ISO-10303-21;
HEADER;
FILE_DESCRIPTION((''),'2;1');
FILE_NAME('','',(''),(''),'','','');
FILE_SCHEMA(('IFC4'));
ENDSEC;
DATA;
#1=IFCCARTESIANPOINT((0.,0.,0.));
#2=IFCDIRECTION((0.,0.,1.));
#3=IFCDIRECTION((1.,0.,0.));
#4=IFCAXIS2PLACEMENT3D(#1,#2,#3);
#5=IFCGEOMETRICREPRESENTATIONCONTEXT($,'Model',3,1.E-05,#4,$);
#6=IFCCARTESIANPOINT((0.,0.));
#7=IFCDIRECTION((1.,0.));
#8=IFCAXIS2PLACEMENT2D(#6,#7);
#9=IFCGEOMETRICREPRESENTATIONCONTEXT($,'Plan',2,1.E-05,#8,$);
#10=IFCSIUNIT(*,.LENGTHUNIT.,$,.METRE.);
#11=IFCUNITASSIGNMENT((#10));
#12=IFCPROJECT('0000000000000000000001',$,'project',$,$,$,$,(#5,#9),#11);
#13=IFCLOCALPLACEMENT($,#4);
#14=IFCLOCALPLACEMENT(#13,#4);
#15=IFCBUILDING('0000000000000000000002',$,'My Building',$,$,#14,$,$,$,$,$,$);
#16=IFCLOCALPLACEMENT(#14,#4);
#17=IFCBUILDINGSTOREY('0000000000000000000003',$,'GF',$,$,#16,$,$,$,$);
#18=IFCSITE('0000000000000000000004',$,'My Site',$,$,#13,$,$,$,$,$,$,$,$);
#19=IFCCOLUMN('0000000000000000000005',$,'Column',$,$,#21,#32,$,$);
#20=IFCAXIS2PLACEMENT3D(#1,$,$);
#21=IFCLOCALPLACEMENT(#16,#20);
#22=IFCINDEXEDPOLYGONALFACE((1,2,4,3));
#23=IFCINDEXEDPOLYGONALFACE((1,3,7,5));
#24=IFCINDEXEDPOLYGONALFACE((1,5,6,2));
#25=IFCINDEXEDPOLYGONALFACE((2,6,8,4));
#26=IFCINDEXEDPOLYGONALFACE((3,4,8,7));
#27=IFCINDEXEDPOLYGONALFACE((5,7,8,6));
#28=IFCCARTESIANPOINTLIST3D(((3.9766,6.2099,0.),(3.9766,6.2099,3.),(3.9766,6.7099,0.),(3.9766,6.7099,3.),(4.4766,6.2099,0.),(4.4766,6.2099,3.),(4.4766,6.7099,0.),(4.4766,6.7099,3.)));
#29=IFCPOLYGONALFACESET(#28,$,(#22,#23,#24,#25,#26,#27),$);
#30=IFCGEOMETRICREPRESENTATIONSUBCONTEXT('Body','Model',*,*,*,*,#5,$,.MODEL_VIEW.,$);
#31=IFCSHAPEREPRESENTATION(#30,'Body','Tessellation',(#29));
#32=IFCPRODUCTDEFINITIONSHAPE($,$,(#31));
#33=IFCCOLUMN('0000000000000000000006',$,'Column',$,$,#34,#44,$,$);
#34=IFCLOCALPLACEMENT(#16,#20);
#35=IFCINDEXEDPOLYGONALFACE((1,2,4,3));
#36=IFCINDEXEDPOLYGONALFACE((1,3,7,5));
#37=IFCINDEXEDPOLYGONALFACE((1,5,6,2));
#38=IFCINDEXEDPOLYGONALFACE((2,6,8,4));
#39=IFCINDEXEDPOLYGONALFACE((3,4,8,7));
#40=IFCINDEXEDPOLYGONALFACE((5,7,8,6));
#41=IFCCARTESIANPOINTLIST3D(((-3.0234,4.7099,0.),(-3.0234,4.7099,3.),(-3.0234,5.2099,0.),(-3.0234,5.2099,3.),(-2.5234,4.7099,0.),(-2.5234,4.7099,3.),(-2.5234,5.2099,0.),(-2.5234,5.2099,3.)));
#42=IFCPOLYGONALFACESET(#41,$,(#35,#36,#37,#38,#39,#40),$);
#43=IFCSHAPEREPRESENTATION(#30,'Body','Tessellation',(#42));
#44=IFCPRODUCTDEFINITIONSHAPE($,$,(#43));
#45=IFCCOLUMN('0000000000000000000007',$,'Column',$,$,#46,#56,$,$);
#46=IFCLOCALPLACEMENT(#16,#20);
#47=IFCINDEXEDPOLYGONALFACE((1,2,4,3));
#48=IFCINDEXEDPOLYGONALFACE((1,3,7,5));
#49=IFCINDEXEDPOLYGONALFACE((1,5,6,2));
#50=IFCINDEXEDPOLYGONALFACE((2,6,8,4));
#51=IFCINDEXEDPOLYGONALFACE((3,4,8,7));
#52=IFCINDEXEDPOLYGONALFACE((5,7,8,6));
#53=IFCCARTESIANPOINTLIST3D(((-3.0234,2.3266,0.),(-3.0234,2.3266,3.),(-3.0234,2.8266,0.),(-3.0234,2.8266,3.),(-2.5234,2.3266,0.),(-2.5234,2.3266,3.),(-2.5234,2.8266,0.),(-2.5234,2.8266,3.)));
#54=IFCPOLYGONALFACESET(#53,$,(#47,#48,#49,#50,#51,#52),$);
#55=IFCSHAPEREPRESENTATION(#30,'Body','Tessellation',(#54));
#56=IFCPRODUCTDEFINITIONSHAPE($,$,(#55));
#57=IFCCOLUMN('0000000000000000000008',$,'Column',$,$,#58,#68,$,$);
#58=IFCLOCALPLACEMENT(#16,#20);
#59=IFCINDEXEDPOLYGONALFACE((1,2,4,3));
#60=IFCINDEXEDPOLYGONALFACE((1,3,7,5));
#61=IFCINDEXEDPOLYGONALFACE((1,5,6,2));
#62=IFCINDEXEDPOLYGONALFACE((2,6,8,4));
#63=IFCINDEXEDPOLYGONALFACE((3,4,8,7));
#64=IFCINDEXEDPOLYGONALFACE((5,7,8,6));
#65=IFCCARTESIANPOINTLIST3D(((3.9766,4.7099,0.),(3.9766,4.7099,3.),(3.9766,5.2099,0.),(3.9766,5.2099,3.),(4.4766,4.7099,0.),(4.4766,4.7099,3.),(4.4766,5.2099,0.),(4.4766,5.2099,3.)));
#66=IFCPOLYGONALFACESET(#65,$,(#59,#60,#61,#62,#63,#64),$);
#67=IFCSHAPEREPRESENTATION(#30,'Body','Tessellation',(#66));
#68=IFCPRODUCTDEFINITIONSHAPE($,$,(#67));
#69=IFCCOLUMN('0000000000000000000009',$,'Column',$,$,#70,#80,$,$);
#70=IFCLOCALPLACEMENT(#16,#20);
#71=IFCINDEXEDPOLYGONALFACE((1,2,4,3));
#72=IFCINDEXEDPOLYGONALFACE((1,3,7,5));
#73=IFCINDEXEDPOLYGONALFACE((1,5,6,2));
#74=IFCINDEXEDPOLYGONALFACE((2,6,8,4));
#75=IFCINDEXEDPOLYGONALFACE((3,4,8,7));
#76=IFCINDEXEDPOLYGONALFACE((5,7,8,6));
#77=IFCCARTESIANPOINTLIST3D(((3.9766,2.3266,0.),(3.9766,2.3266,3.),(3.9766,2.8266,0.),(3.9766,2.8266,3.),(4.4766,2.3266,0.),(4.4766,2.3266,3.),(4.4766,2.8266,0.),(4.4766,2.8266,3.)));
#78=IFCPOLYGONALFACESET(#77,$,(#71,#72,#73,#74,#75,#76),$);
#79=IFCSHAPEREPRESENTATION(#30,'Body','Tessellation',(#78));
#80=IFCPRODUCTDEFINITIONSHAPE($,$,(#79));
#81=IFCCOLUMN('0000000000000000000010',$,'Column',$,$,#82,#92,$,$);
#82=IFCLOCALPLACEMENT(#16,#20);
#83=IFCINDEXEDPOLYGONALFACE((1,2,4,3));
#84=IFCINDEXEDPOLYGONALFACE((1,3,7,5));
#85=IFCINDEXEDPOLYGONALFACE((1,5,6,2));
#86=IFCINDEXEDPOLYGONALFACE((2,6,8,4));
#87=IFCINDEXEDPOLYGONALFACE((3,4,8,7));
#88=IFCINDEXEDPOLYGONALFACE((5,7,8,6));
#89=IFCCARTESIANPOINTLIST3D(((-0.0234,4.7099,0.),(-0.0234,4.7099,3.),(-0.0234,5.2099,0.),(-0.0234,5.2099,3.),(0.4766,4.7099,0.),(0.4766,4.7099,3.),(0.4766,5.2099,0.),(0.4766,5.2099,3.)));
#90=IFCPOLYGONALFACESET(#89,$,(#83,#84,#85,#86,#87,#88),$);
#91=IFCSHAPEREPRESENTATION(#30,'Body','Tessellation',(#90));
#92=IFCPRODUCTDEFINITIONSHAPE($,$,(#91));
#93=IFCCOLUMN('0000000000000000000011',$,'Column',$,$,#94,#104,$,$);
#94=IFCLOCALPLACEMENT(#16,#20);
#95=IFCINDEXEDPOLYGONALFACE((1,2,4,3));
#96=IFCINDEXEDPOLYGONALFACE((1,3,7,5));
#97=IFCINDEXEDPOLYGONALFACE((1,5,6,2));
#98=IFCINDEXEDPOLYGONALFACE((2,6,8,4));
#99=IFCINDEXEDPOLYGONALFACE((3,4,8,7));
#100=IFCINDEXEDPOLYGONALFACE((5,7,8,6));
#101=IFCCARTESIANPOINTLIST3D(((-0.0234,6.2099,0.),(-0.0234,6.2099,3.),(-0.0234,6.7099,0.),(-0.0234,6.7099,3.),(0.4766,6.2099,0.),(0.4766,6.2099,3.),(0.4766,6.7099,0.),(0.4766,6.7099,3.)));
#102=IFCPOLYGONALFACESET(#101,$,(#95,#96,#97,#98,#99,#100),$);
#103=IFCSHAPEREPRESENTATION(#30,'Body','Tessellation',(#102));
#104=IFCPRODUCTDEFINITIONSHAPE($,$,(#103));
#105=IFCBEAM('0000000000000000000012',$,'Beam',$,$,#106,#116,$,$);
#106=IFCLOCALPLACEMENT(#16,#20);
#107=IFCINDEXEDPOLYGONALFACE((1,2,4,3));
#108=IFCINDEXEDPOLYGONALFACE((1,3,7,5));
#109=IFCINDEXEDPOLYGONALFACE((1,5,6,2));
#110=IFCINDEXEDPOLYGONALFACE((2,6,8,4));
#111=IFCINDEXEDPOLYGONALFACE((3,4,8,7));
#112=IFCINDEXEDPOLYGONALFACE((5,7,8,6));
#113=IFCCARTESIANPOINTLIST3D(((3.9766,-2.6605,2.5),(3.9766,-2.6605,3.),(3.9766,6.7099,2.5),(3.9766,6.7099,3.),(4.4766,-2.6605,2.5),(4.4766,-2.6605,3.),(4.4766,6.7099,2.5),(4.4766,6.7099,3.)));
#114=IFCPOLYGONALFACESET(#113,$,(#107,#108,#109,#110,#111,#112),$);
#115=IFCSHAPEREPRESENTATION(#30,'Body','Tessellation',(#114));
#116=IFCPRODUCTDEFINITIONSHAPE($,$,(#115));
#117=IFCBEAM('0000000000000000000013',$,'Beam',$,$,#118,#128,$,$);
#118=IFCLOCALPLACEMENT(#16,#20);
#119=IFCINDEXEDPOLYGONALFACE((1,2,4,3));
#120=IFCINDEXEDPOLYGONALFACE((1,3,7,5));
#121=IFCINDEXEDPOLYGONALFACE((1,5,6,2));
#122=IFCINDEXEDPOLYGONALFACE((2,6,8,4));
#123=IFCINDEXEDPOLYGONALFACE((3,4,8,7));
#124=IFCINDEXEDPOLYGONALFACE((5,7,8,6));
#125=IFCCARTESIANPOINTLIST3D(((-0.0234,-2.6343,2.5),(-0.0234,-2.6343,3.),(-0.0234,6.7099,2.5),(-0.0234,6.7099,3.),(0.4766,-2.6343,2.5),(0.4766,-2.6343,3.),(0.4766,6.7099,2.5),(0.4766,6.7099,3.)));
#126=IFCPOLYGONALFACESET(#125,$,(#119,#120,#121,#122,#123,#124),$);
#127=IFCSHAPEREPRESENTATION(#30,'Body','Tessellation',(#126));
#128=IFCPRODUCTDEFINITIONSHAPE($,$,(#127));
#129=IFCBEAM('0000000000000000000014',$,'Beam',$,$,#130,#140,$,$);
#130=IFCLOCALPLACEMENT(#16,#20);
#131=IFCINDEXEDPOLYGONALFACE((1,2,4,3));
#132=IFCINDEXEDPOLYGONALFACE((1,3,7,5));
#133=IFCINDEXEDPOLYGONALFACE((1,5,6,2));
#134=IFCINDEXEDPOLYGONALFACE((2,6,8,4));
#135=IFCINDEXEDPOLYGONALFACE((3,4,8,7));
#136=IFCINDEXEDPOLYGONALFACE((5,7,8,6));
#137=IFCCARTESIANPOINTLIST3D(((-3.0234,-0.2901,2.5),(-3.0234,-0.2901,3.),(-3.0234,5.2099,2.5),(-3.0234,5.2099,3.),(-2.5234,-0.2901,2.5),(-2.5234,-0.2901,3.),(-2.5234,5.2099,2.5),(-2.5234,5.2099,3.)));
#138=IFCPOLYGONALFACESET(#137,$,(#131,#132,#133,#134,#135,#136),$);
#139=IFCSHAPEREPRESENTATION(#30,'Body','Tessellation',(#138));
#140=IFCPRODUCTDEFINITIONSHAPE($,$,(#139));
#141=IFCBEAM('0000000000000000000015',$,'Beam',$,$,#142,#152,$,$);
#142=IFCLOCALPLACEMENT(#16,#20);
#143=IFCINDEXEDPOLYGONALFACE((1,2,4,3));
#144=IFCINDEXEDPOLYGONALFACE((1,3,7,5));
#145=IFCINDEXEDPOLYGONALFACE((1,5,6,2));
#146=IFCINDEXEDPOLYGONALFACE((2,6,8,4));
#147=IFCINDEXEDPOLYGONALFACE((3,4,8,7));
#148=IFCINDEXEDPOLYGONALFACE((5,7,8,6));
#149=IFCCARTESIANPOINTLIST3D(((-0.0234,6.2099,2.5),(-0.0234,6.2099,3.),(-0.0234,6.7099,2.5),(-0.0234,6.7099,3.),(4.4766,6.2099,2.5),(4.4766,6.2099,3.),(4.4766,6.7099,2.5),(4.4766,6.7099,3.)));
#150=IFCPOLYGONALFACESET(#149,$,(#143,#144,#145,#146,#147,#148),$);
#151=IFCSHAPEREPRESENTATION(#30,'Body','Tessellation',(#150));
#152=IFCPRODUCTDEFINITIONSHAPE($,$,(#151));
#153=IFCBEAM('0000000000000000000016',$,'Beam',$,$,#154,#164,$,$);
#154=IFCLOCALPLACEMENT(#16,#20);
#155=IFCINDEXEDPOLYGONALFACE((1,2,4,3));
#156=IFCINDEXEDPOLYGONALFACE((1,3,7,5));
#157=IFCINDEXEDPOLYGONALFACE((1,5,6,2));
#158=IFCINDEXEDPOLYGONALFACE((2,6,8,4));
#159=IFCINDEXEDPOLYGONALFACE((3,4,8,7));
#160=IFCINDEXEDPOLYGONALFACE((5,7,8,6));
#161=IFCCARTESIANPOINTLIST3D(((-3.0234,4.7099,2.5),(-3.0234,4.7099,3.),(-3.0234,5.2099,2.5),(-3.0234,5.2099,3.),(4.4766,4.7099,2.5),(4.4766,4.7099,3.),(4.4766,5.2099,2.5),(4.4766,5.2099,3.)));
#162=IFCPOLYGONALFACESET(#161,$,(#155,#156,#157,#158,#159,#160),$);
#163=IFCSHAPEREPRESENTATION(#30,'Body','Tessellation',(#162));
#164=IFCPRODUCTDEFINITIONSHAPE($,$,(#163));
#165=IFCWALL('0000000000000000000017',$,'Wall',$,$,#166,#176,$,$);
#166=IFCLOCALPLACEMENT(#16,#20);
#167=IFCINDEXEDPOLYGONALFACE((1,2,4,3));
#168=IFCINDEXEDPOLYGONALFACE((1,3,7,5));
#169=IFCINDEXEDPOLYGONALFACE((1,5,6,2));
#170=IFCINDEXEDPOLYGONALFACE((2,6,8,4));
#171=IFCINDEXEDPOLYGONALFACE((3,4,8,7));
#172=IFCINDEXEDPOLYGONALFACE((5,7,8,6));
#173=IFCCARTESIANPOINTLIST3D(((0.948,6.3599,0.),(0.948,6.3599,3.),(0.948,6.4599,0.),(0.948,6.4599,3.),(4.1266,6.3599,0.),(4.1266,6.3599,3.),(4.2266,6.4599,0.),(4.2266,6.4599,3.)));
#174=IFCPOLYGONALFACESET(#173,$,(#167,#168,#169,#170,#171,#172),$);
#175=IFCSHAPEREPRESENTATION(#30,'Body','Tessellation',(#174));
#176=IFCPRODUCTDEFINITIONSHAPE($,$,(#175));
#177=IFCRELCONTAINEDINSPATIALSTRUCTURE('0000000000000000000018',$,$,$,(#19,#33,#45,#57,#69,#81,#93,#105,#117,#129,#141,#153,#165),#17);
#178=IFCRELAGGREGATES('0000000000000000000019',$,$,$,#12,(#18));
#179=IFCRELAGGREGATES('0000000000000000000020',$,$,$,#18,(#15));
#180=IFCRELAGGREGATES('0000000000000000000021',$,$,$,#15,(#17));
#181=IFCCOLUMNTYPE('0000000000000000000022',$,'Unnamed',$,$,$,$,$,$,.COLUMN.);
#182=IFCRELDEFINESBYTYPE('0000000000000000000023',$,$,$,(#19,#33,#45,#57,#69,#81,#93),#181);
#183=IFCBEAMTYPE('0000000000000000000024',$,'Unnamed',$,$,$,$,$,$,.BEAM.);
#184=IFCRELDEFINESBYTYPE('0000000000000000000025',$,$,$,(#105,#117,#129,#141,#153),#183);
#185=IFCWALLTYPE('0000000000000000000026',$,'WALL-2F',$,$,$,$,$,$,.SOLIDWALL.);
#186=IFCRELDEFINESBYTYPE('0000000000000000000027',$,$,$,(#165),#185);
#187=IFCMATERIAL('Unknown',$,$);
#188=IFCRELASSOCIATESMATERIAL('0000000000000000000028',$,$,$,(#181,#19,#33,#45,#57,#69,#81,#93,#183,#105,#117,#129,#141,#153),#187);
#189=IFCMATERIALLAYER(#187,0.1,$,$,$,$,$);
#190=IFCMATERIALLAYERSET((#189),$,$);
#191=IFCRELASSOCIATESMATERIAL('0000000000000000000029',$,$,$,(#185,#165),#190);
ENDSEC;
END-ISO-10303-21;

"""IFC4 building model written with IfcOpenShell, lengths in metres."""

from ifc_helpers import new_model, si_unit, frame, origin_with_axes, origin_2d_with_axis, place, context, subcontext, project, spatial, line, indexed_curve, rectangle, outline, extrude, material, layer, layer_set, layer_usage, material_profile, profile_set, profile_usage, type_object, element, save


model = new_model("IFC4")

# Units and contexts
model_context = context("Model", 3, precision=1e-05, world=origin_with_axes())
plan_context = context("Plan", 2, precision=1e-05, world=origin_2d_with_axis())
body_context_1 = subcontext(model_context, "Body", "Model", "MODEL_VIEW")
ifc_project = project(units=[si_unit("LENGTHUNIT", "METRE")], contexts=[model_context, plan_context])

# Site, building, storey
site_placement = place(None, origin_with_axes())
site = spatial("IfcSite", under=ifc_project, at=site_placement, Name="My Site")
building_placement = place(site_placement, origin_with_axes())
building = spatial("IfcBuilding", under=site, at=building_placement, Name="My Building")
storey_placement = place(building_placement, origin_with_axes())
storey = spatial("IfcBuildingStorey", under=building, at=storey_placement, Name="GF")

# Columns
ifc_material_1 = material(Name="Unknown")
ifc_material_profile_1 = material_profile(ifc_material_1, rectangle(XDim=0.5, YDim=0.5))
ifc_profile_set_1 = profile_set([ifc_material_profile_1])
ifc_profile_usage_1 = profile_usage(ifc_profile_set_1, cardinal=5)
column_type = type_object("IfcColumnType", Name="Unnamed", PredefinedType="COLUMN", material=ifc_profile_set_1)
column_1_placement = place(storey_placement, frame((4.2266, 6.4599, 0.0), z_axis=(0.0, 0.0, 1.0), x_axis=(1.0, 0.0, 0.0)))
element("IfcColumn", 1, at=column_1_placement, inside=storey, type_object=column_type, material=ifc_profile_usage_1, Name="Column", context=body_context_1, shape_type="SweptSolid", body=[
    extrude(rectangle(XDim=0.5, YDim=0.5), origin_with_axes(), (0.0, 0.0, 1.0), 3.0),
])
ifc_profile_usage_2 = profile_usage(ifc_profile_set_1, cardinal=5)
column_2_placement = place(storey_placement, frame((-2.7734, 4.9599, 0.0), z_axis=(0.0, 0.0, 1.0), x_axis=(1.0, 0.0, 0.0)))
element("IfcColumn", 2, at=column_2_placement, inside=storey, type_object=column_type, material=ifc_profile_usage_2, Name="Column", context=body_context_1, shape_type="SweptSolid", body=[
    extrude(rectangle(XDim=0.5, YDim=0.5), origin_with_axes(), (0.0, 0.0, 1.0), 3.0),
])
ifc_profile_usage_3 = profile_usage(ifc_profile_set_1, cardinal=5)
column_3_placement = place(storey_placement, frame((-2.7734, 2.5766, 0.0), z_axis=(0.0, 0.0, 1.0), x_axis=(1.0, 0.0, 0.0)))
element("IfcColumn", 3, at=column_3_placement, inside=storey, type_object=column_type, material=ifc_profile_usage_3, Name="Column", context=body_context_1, shape_type="SweptSolid", body=[
    extrude(rectangle(XDim=0.5, YDim=0.5), origin_with_axes(), (0.0, 0.0, 1.0), 3.0),
])
ifc_profile_usage_4 = profile_usage(ifc_profile_set_1, cardinal=5)
column_4_placement = place(storey_placement, frame((4.2266, 4.9599, 0.0), z_axis=(0.0, 0.0, 1.0), x_axis=(1.0, 0.0, 0.0)))
element("IfcColumn", 4, at=column_4_placement, inside=storey, type_object=column_type, material=ifc_profile_usage_4, Name="Column", context=body_context_1, shape_type="SweptSolid", body=[
    extrude(rectangle(XDim=0.5, YDim=0.5), origin_with_axes(), (0.0, 0.0, 1.0), 3.0),
])
ifc_profile_usage_5 = profile_usage(ifc_profile_set_1, cardinal=5)
column_5_placement = place(storey_placement, frame((4.2266, 2.5766, 0.0), z_axis=(0.0, 0.0, 1.0), x_axis=(1.0, 0.0, 0.0)))
element("IfcColumn", 5, at=column_5_placement, inside=storey, type_object=column_type, material=ifc_profile_usage_5, Name="Column", context=body_context_1, shape_type="SweptSolid", body=[
    extrude(rectangle(XDim=0.5, YDim=0.5), origin_with_axes(), (0.0, 0.0, 1.0), 3.0),
])
ifc_profile_usage_6 = profile_usage(ifc_profile_set_1, cardinal=5)
column_6_placement = place(storey_placement, frame((0.2266, 4.9599, 0.0), z_axis=(0.0, 0.0, 1.0), x_axis=(1.0, 0.0, 0.0)))
element("IfcColumn", 6, at=column_6_placement, inside=storey, type_object=column_type, material=ifc_profile_usage_6, Name="Column", context=body_context_1, shape_type="SweptSolid", body=[
    extrude(rectangle(XDim=0.5, YDim=0.5), origin_with_axes(), (0.0, 0.0, 1.0), 3.0),
])
ifc_profile_usage_7 = profile_usage(ifc_profile_set_1, cardinal=5)
column_7_placement = place(storey_placement, frame((0.2266, 6.4599, 0.0), z_axis=(0.0, 0.0, 1.0), x_axis=(1.0, 0.0, 0.0)))
element("IfcColumn", 7, at=column_7_placement, inside=storey, type_object=column_type, material=ifc_profile_usage_7, Name="Column", context=body_context_1, shape_type="SweptSolid", body=[
    extrude(rectangle(XDim=0.5, YDim=0.5), origin_with_axes(), (0.0, 0.0, 1.0), 3.0),
])

# Beams
ifc_material_profile_2 = material_profile(ifc_material_1, rectangle(XDim=0.5, YDim=0.5))
ifc_profile_set_2 = profile_set([ifc_material_profile_2])
ifc_profile_usage_8 = profile_usage(ifc_profile_set_2, cardinal=7)
beam_type = type_object("IfcBeamType", Name="Unnamed", PredefinedType="BEAM", material=ifc_profile_set_2)
beam_1_placement = place(storey_placement, frame((4.4766, 6.7099, 3.0), z_axis=(0.0, -1.0, 0.0), x_axis=(1.0, 0.0, 0.0)))
element("IfcBeam", 8, at=beam_1_placement, inside=storey, type_object=beam_type, material=ifc_profile_usage_8, Name="Beam", context=body_context_1, shape_type="SweptSolid", body=[
    extrude(rectangle(XDim=0.5, YDim=0.5), frame((-0.25, -0.25, 0.0), z_axis=(0.0, 0.0, 1.0), x_axis=(1.0, 0.0, 0.0)), (0.0, 0.0, 1.0), 9.3704),
])
ifc_profile_usage_9 = profile_usage(ifc_profile_set_2, cardinal=7)
beam_2_placement = place(storey_placement, frame((0.4766, 6.7099, 3.0), z_axis=(0.0, -1.0, 0.0), x_axis=(1.0, 0.0, 0.0)))
element("IfcBeam", 9, at=beam_2_placement, inside=storey, type_object=beam_type, material=ifc_profile_usage_9, Name="Beam", context=body_context_1, shape_type="SweptSolid", body=[
    extrude(rectangle(XDim=0.5, YDim=0.5), frame((-0.25, -0.25, 0.0), z_axis=(0.0, 0.0, 1.0), x_axis=(1.0, 0.0, 0.0)), (0.0, 0.0, 1.0), 9.3442),
])
ifc_profile_usage_10 = profile_usage(ifc_profile_set_2, cardinal=7)
beam_3_placement = place(storey_placement, frame((-2.5234, 5.2099, 3.0), z_axis=(0.0, -1.0, 0.0), x_axis=(1.0, 0.0, 0.0)))
element("IfcBeam", 10, at=beam_3_placement, inside=storey, type_object=beam_type, material=ifc_profile_usage_10, Name="Beam", context=body_context_1, shape_type="SweptSolid", body=[
    extrude(rectangle(XDim=0.5, YDim=0.5), frame((-0.25, -0.25, 0.0), z_axis=(0.0, 0.0, 1.0), x_axis=(1.0, 0.0, 0.0)), (0.0, 0.0, 1.0), 5.5),
])
ifc_profile_usage_11 = profile_usage(ifc_profile_set_2, cardinal=7)
beam_4_placement = place(storey_placement, frame((-0.0234, 6.7099, 3.0), z_axis=(1.0, 0.0, 0.0), x_axis=(0.0, 1.0, 0.0)))
element("IfcBeam", 11, at=beam_4_placement, inside=storey, type_object=beam_type, material=ifc_profile_usage_11, Name="Beam", context=body_context_1, shape_type="SweptSolid", body=[
    extrude(rectangle(XDim=0.5, YDim=0.5), frame((-0.25, -0.25, 0.0), z_axis=(0.0, 0.0, 1.0), x_axis=(1.0, 0.0, 0.0)), (0.0, 0.0, 1.0), 4.5),
])
ifc_profile_usage_12 = profile_usage(ifc_profile_set_2, cardinal=7)
beam_5_placement = place(storey_placement, frame((4.4766, 4.7099, 3.0), z_axis=(-1.0, 0.0, 0.0), x_axis=(0.0, -1.0, 0.0)))
element("IfcBeam", 12, at=beam_5_placement, inside=storey, type_object=beam_type, material=ifc_profile_usage_12, Name="Beam", context=body_context_1, shape_type="SweptSolid", body=[
    extrude(rectangle(XDim=0.5, YDim=0.5), frame((-0.25, -0.25, 0.0), z_axis=(0.0, 0.0, 1.0), x_axis=(1.0, 0.0, 0.0)), (0.0, 0.0, 1.0), 7.5),
])

# Wall
ifc_layer_1 = layer(ifc_material_1, 0.1)
ifc_layer_set_1 = layer_set([ifc_layer_1])
ifc_layer_usage_1 = layer_usage(ifc_layer_set_1, "AXIS2", "POSITIVE", 0.0)
wall_type_1 = type_object("IfcWallType", Name="WALL-2F", PredefinedType="SOLIDWALL", material=ifc_layer_set_1)
wall_1_placement = place(storey_placement, frame((4.2266, 6.4599, 0.0), z_axis=(0.0, 0.0, 1.0), x_axis=(-1.0, 0.0, 0.0)))
element("IfcWall", 13, at=wall_1_placement, inside=storey, type_object=wall_type_1, material=ifc_layer_usage_1, Name="Wall", context=body_context_1, shape_type="SweptSolid", body=[
    extrude(outline(indexed_curve([(0.0, 0.0), (0.1, 0.1), (3.2786, 0.1), (3.2786, 0.0)], segments=[line(1, 2, 3, 4, 1)])), origin_with_axes(), (0.0, 0.0, 1.0), 3.0),
])

save(model, "model.ifc")
